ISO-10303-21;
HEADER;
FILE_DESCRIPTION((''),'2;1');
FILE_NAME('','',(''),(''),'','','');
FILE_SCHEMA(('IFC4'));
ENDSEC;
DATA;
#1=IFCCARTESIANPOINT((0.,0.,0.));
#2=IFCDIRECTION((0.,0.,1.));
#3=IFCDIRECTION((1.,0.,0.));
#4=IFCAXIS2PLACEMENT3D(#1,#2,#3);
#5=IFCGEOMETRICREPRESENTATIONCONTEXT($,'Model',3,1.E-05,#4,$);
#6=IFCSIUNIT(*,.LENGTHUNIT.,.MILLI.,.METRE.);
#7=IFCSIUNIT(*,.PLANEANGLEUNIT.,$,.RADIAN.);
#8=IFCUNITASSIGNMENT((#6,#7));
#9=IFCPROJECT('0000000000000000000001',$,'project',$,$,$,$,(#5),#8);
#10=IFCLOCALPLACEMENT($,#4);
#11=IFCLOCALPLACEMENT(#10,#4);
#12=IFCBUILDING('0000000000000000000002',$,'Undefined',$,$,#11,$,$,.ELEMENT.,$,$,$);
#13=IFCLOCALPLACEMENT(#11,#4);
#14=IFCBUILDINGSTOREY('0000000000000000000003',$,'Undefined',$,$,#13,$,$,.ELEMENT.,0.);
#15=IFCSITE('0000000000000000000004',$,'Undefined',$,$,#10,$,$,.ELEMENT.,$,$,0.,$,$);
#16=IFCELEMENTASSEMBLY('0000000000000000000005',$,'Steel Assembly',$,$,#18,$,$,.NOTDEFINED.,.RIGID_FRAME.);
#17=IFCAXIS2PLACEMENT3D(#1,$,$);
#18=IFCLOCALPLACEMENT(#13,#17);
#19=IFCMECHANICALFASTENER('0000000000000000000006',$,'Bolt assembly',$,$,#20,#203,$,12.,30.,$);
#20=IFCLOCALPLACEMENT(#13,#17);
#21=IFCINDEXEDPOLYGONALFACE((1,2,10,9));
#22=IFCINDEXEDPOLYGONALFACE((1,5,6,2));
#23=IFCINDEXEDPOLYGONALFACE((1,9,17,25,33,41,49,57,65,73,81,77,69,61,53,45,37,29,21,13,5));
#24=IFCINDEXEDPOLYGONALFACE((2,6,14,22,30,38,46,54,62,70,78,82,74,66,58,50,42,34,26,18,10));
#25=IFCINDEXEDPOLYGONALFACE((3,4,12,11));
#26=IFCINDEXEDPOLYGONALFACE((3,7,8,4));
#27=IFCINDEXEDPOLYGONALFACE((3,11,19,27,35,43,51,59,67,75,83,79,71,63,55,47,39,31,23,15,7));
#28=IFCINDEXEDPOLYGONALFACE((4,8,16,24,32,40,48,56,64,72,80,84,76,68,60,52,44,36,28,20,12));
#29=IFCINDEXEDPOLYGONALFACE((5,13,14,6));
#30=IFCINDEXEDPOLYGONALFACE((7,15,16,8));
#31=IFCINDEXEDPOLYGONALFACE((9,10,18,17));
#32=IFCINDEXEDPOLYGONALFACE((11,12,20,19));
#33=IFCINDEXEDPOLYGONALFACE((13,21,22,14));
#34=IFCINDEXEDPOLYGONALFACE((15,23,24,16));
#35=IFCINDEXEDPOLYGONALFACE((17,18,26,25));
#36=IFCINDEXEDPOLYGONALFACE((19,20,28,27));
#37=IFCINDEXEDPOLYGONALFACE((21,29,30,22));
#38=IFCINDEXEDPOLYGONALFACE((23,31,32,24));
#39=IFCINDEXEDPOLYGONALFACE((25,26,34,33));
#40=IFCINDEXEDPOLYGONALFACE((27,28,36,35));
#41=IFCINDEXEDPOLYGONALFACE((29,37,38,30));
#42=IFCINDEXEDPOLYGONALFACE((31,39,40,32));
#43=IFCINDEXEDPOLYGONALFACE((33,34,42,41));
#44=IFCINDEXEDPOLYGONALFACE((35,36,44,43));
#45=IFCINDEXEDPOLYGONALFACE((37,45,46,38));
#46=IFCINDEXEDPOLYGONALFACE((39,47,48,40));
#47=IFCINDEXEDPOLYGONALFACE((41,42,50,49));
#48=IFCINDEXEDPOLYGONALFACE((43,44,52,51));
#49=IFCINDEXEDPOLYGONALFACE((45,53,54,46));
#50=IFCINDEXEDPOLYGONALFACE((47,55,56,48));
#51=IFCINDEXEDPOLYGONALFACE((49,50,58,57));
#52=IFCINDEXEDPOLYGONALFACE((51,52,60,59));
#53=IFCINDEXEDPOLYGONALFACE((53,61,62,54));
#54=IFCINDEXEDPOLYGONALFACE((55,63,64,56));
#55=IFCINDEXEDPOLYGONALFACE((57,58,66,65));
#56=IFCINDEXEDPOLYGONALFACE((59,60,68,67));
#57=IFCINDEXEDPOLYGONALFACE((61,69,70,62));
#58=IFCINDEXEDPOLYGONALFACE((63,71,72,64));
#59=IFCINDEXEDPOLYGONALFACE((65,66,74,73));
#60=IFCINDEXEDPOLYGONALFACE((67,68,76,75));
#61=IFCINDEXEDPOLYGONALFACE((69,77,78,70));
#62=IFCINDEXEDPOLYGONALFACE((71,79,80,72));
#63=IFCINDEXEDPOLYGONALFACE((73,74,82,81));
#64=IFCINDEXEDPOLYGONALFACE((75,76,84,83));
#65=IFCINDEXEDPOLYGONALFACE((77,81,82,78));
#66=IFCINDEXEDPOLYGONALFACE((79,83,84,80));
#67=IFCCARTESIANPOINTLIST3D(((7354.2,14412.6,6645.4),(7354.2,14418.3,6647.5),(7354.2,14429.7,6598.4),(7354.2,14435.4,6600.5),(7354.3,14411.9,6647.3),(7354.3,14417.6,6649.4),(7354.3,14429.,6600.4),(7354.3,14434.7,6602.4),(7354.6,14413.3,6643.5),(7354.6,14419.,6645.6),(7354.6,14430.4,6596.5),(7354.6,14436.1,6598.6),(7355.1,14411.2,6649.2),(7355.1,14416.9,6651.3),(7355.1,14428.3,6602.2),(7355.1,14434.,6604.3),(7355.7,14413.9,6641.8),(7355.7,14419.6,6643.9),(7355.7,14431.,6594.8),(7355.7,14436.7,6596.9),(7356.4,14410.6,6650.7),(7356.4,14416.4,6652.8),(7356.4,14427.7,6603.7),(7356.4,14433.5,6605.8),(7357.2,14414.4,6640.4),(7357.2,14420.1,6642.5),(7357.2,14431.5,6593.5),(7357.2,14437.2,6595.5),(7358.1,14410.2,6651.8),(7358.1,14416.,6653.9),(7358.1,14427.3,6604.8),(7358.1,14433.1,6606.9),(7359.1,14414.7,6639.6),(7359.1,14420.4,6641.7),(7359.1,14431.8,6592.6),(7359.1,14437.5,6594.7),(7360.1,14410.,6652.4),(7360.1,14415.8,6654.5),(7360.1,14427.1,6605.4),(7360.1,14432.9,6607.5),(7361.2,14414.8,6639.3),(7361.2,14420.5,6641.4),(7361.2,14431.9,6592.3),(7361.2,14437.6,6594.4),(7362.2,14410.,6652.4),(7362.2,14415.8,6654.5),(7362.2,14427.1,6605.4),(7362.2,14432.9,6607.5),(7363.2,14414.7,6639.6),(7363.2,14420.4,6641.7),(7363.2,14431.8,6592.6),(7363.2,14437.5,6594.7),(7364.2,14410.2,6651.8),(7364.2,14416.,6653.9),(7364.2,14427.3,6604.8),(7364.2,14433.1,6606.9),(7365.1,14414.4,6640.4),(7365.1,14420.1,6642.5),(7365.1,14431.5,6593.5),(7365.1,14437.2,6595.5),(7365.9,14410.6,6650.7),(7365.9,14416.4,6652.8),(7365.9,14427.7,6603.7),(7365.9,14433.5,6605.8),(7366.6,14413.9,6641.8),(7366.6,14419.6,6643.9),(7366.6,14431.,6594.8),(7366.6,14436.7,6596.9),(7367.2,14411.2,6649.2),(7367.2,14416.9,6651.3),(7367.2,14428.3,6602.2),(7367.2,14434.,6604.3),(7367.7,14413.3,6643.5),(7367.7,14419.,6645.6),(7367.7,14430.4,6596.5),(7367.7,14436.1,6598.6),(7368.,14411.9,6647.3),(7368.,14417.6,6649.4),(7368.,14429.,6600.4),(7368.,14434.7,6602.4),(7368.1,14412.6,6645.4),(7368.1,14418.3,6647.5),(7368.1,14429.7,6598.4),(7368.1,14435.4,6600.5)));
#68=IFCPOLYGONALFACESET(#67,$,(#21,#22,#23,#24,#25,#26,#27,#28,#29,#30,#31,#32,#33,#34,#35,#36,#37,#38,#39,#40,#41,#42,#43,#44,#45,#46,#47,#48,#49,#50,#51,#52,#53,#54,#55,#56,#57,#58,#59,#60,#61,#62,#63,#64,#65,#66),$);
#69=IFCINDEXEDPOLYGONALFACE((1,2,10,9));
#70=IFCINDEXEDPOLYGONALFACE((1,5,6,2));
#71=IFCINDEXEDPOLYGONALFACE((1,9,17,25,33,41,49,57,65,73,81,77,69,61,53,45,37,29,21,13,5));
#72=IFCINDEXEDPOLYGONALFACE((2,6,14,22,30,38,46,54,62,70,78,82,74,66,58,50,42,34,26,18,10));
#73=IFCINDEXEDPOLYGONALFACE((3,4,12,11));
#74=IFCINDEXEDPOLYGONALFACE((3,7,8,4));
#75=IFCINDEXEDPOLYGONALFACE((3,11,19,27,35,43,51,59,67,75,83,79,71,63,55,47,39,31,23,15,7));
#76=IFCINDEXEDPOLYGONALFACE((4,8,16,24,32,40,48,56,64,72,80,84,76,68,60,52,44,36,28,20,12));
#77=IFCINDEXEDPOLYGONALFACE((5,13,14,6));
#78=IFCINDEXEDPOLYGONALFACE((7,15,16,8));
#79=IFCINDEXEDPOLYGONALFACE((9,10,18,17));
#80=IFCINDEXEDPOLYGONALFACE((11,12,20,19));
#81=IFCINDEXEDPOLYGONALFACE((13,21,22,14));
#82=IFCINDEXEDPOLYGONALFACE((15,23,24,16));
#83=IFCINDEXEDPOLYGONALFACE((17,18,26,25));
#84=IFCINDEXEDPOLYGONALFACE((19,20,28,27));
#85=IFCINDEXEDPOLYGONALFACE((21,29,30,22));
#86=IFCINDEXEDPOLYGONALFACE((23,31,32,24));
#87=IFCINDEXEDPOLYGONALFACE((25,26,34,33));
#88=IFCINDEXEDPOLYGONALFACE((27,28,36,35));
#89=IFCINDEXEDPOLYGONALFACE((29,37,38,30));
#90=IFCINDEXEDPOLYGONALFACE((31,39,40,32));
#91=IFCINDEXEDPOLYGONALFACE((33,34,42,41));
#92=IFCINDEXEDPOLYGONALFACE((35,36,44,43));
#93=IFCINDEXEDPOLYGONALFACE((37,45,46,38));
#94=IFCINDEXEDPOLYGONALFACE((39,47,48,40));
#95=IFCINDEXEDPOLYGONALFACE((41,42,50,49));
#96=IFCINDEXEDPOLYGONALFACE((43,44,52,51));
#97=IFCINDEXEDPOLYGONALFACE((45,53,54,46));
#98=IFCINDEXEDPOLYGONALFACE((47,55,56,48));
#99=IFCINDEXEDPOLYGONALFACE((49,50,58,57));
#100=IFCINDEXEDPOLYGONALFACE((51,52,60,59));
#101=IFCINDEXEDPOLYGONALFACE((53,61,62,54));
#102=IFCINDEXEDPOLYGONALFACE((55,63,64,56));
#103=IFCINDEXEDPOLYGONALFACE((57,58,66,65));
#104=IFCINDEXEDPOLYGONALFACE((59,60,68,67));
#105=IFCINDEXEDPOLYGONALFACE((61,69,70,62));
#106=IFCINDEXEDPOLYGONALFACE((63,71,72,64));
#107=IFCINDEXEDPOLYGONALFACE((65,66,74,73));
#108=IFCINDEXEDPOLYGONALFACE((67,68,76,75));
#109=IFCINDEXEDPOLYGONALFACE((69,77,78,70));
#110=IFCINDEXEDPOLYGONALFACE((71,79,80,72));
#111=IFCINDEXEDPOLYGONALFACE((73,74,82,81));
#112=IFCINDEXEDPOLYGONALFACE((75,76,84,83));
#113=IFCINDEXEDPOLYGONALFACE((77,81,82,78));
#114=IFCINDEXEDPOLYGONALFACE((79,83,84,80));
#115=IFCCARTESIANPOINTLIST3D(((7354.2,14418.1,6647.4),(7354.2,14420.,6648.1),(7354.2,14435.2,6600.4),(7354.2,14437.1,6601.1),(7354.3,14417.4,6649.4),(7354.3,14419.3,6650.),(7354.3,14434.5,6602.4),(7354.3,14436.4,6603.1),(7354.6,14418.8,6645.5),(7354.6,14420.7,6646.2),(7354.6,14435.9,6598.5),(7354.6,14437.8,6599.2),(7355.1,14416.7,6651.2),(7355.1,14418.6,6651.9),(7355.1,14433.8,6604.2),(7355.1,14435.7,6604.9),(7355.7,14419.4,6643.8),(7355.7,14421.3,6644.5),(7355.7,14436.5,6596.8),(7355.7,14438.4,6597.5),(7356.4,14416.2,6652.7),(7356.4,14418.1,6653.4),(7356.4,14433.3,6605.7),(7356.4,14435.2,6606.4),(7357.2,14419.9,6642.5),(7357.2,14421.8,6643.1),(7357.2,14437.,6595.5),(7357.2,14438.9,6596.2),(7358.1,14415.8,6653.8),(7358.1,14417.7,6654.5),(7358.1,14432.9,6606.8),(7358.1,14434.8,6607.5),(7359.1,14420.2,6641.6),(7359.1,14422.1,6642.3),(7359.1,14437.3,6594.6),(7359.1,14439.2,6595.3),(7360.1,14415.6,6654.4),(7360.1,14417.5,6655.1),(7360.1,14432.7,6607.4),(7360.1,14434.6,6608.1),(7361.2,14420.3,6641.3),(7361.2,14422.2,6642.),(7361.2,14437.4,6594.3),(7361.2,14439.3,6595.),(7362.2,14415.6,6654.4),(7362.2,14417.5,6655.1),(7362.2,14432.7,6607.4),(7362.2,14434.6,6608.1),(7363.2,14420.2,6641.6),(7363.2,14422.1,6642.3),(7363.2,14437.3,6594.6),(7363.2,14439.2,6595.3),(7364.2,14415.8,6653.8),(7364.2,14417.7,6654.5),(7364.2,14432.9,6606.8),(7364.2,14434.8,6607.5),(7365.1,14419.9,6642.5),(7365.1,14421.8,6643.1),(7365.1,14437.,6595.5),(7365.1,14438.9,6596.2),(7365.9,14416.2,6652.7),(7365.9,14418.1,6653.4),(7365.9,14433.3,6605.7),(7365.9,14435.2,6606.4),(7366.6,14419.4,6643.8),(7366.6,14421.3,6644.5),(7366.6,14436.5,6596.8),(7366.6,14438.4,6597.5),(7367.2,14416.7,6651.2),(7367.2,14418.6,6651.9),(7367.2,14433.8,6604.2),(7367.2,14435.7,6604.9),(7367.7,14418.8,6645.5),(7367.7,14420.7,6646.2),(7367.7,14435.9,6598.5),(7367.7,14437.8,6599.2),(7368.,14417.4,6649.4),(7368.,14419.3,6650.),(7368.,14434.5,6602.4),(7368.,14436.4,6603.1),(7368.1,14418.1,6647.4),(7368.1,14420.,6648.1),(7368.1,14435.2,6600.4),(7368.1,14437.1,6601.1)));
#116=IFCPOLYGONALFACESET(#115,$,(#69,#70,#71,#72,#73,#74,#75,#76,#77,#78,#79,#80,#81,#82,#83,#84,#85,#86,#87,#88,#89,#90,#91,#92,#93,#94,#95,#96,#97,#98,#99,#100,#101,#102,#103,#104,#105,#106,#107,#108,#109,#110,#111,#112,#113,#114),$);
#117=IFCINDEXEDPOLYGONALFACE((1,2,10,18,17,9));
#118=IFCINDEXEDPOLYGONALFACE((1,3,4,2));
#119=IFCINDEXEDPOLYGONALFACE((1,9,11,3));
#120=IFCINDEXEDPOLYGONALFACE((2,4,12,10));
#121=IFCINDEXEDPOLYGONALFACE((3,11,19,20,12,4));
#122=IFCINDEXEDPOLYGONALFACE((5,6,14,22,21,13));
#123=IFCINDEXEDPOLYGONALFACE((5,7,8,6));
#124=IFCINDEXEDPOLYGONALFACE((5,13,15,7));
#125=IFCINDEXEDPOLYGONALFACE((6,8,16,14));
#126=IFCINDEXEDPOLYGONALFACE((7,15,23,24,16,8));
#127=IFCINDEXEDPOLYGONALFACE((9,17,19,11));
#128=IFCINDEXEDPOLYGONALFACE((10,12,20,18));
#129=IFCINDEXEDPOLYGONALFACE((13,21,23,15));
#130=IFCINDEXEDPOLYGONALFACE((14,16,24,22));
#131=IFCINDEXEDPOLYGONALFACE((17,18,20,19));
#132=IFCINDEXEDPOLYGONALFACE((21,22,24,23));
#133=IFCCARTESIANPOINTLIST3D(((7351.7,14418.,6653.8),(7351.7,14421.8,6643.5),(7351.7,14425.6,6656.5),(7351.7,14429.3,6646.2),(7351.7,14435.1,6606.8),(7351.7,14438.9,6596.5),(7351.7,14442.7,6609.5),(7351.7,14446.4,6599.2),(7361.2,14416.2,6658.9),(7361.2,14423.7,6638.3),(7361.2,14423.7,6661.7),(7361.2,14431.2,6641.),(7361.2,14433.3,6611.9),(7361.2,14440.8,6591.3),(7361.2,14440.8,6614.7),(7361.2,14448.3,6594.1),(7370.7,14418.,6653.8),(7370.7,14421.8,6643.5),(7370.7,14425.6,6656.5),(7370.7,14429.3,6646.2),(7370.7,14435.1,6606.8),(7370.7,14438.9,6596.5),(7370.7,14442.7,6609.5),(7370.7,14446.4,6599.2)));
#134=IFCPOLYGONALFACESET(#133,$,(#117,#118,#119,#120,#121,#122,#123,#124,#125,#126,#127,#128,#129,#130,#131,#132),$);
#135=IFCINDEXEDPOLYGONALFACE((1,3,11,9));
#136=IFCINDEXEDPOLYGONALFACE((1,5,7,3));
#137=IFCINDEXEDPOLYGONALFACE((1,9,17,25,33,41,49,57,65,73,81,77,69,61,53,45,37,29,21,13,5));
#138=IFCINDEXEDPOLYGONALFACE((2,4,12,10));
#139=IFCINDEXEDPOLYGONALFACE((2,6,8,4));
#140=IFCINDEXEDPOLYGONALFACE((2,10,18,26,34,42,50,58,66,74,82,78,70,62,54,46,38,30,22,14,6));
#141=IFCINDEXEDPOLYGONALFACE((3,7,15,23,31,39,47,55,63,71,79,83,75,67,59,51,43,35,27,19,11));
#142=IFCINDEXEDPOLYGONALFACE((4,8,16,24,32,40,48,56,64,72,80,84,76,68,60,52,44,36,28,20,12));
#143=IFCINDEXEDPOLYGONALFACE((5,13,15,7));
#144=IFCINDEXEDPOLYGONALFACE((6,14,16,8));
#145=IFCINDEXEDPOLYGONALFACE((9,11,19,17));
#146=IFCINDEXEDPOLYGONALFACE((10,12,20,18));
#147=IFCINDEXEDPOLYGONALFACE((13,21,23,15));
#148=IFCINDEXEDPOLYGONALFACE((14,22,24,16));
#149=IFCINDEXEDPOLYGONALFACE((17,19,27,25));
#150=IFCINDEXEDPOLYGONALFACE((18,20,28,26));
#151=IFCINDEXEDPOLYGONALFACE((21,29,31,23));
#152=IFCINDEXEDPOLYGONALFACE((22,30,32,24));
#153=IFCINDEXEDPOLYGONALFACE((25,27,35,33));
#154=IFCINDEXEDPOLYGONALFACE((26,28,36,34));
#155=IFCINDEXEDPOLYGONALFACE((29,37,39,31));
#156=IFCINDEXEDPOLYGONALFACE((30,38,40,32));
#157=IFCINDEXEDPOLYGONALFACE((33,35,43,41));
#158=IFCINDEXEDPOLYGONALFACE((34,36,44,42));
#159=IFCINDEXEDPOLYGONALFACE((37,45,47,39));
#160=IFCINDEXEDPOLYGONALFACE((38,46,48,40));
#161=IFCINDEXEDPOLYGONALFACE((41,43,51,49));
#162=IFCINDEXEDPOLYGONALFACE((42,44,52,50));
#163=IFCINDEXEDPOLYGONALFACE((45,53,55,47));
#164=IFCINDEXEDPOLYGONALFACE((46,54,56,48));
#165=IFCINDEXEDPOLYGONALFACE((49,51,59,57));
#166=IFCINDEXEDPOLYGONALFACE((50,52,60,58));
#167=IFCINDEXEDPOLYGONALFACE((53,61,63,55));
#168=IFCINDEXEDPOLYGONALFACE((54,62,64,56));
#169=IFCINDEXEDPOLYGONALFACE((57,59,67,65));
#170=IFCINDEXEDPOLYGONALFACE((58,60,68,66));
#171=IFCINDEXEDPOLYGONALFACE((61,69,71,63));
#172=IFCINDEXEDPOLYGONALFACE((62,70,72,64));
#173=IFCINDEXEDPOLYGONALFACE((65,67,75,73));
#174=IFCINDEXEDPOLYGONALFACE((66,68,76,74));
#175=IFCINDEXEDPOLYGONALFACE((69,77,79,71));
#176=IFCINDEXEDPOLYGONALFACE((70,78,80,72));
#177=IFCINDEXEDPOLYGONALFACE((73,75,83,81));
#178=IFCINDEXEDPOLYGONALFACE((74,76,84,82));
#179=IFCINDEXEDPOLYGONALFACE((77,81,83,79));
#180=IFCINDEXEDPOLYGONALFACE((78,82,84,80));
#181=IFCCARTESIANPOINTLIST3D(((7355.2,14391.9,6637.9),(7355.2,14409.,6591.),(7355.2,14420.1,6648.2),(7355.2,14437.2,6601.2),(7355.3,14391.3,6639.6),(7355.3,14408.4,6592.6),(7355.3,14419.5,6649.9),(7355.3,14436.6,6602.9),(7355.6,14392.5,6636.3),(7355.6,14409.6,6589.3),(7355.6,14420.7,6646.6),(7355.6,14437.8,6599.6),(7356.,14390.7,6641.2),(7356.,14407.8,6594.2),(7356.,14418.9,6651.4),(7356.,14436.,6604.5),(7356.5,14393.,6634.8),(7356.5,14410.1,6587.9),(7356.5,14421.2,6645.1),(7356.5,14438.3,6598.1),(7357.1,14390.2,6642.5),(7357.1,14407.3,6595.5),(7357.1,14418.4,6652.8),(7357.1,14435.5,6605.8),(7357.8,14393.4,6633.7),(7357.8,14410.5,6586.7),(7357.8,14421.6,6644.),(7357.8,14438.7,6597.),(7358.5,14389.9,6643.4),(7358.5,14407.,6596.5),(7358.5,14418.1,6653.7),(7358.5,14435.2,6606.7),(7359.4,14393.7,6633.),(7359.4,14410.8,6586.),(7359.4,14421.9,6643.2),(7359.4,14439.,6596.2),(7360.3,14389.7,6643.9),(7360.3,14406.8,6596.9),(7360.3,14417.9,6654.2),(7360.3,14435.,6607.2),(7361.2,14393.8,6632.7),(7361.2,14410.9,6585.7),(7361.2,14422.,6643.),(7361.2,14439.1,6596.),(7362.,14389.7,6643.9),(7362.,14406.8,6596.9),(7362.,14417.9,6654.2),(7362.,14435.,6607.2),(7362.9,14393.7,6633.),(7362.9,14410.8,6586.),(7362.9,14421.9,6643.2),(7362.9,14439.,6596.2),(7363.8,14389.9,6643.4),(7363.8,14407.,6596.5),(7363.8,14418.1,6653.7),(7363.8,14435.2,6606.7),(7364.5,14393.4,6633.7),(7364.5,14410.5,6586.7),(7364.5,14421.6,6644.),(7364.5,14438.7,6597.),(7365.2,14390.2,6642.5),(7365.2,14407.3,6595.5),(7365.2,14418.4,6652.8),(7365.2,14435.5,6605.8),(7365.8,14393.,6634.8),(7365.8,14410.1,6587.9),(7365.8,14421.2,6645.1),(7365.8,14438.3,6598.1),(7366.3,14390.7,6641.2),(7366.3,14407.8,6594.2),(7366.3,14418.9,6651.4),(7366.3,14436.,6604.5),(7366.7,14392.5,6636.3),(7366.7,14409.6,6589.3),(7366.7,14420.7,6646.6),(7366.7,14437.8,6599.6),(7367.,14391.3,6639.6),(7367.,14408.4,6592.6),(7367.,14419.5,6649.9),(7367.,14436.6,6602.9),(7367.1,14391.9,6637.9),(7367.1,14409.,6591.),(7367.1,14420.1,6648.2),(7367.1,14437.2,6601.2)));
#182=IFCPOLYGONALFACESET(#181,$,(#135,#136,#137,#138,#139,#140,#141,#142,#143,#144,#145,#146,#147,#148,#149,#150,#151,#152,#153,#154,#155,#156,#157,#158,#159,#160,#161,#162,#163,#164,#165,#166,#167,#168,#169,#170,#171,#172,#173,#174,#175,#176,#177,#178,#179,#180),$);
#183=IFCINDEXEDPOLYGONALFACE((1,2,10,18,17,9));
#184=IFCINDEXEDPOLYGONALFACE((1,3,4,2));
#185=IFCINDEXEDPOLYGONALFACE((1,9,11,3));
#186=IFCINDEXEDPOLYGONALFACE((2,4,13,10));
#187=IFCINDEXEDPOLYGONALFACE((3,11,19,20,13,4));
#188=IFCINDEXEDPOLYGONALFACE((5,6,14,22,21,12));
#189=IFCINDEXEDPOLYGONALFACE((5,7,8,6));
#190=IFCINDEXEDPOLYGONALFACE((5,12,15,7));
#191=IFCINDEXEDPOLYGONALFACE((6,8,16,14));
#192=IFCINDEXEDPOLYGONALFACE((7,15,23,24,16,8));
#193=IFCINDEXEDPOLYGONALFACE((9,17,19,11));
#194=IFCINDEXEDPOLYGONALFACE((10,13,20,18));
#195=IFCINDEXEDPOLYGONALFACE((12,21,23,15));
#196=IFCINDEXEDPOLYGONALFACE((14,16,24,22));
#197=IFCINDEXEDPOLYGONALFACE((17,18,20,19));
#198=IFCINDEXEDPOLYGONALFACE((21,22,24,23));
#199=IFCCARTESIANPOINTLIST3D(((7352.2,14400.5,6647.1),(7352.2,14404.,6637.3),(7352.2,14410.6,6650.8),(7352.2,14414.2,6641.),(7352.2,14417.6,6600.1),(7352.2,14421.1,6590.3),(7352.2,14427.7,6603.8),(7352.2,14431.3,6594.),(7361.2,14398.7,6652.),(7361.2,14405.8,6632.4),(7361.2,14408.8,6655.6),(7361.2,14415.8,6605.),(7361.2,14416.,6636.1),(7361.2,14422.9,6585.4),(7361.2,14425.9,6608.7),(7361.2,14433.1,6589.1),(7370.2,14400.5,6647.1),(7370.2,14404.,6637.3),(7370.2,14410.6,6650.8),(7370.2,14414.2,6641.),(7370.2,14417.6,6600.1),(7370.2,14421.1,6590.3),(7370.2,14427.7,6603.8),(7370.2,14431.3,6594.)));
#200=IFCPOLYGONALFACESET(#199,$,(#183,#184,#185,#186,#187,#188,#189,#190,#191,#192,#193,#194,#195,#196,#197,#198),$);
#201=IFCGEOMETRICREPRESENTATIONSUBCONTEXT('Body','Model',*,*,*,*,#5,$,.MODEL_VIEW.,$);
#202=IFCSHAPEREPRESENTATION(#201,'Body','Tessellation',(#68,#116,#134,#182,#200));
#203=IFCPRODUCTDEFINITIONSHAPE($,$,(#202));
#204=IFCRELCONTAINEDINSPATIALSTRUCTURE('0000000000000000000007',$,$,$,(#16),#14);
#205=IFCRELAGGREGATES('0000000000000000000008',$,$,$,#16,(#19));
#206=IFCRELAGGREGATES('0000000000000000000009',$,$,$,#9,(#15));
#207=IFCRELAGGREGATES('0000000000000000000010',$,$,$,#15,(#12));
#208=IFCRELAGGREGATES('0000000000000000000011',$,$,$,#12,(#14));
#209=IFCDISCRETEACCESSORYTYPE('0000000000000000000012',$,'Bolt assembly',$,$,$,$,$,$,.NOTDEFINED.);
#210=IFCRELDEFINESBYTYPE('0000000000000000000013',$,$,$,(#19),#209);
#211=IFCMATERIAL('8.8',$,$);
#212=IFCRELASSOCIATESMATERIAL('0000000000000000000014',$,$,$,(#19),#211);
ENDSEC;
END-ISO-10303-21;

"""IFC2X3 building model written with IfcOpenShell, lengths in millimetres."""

from ifc_helpers import new_model, si_unit, frame, origin_with_axes, origin_2d_with_axis, place, context, subcontext, project, spatial, polyline, circle, outline, extrude, source, transform, mapped, material, type_object, element, aggregate, save


model = new_model("IFC2X3")

# Units and contexts
model_context = context("Model", 3, precision=1e-05, world=origin_with_axes())
body_context = subcontext(model_context, "Body", "Model", "MODEL_VIEW")
ifc_project = project(units=[si_unit("LENGTHUNIT", "METRE", prefix="MILLI"), si_unit("PLANEANGLEUNIT", "RADIAN")], contexts=[model_context])

# Site, building, storey
site_placement = place(None, origin_with_axes())
site = spatial("IfcSite", under=ifc_project, at=site_placement, Name="Undefined", CompositionType="ELEMENT", RefElevation=0.0)
building_placement = place(site_placement, origin_with_axes())
building = spatial("IfcBuilding", under=site, at=building_placement, Name="Undefined", CompositionType="ELEMENT")
storey_placement = place(building_placement, origin_with_axes())
storey = spatial("IfcBuildingStorey", under=building, at=storey_placement, Name="Undefined", CompositionType="ELEMENT", Elevation=0.0)

# Shared definitions
ifc_material_1 = material(Name="8.8")
discrete_accessory_type_1 = type_object("IfcDiscreteAccessoryType", Name="Bolt assembly")

# Element assembly
assembly_1_placement = place(storey_placement, origin_with_axes())
assembly_1 = element("IfcElementAssembly", 1, at=assembly_1_placement, inside=storey, Name="Steel Assembly", AssemblyPlace="NOTDEFINED", PredefinedType="RIGID_FRAME")

# Shared definitions
shared_shape_1 = source(origin_with_axes(), body_context, "Body", "SweptSolid", [
    extrude(circle(Radius=7.0, at=origin_2d_with_axis()), frame((0.0, -6.1, 0.0), z_axis=(0.0, 1.0, 0.0), x_axis=(1.0, 0.0, 0.0)), (0.0, 0.0, 1.0), 6.1),
    extrude(circle(Radius=7.0, at=origin_2d_with_axis()), frame((0.0, -7.9, 0.0), z_axis=(0.0, 1.0, 0.0), x_axis=(1.0, 0.0, 0.0)), (0.0, 0.0, 1.0), 2.0),
    extrude(outline(polyline([(11.0, 0.0), (5.5, 9.5), (-5.5, 9.5), (-11.0, 0.0), (-5.5, -9.5), (5.5, -9.5), (11.0, 0.0)])), frame((0.0, -16.0, 0.0), z_axis=(0.0, 1.0, 0.0), x_axis=(1.0, 0.0, 0.0)), (0.0, 0.0, 1.0), 8.0),
    extrude(circle(Radius=6.0, at=origin_2d_with_axis()), frame((0.0, -8.0, 0.0), z_axis=(0.0, 1.0, 0.0), x_axis=(1.0, 0.0, 0.0)), (0.0, 0.0, 1.0), 30.0),
    extrude(outline(polyline([(10.4, 0.0), (5.2, 9.0), (-5.2, 9.0), (-10.4, 0.0), (-5.2, -9.0), (5.2, -9.0), (10.4, 0.0)])), frame((0.0, 0.0, 0.0), z_axis=(0.0, 1.0, 0.0), x_axis=(1.0, 0.0, 0.0)), (0.0, 0.0, 1.0), 10.8),
])

# Mechanical fastener
mechanical_fastener_1_placement = place(assembly_1_placement, frame((7361.2, 14412.4, 6645.9), z_axis=(-1.0, 0.0, 0.0), x_axis=(0.0, 0.34202, -0.939693)))
mechanical_fastener_1 = element("IfcMechanicalFastener", 2, at=mechanical_fastener_1_placement, type_object=discrete_accessory_type_1, material=ifc_material_1, Name="Bolt assembly", NominalDiameter=12.0, NominalLength=30.0, context=body_context, shape_type="MappedRepresentation", body=[
    mapped(shared_shape_1, transform((0.0, 0.0, 0.0))),
    mapped(shared_shape_1, transform((50.0, 0.0, 0.0))),
])
aggregate(assembly_1, [mechanical_fastener_1])

save(model, "model.ifc")
